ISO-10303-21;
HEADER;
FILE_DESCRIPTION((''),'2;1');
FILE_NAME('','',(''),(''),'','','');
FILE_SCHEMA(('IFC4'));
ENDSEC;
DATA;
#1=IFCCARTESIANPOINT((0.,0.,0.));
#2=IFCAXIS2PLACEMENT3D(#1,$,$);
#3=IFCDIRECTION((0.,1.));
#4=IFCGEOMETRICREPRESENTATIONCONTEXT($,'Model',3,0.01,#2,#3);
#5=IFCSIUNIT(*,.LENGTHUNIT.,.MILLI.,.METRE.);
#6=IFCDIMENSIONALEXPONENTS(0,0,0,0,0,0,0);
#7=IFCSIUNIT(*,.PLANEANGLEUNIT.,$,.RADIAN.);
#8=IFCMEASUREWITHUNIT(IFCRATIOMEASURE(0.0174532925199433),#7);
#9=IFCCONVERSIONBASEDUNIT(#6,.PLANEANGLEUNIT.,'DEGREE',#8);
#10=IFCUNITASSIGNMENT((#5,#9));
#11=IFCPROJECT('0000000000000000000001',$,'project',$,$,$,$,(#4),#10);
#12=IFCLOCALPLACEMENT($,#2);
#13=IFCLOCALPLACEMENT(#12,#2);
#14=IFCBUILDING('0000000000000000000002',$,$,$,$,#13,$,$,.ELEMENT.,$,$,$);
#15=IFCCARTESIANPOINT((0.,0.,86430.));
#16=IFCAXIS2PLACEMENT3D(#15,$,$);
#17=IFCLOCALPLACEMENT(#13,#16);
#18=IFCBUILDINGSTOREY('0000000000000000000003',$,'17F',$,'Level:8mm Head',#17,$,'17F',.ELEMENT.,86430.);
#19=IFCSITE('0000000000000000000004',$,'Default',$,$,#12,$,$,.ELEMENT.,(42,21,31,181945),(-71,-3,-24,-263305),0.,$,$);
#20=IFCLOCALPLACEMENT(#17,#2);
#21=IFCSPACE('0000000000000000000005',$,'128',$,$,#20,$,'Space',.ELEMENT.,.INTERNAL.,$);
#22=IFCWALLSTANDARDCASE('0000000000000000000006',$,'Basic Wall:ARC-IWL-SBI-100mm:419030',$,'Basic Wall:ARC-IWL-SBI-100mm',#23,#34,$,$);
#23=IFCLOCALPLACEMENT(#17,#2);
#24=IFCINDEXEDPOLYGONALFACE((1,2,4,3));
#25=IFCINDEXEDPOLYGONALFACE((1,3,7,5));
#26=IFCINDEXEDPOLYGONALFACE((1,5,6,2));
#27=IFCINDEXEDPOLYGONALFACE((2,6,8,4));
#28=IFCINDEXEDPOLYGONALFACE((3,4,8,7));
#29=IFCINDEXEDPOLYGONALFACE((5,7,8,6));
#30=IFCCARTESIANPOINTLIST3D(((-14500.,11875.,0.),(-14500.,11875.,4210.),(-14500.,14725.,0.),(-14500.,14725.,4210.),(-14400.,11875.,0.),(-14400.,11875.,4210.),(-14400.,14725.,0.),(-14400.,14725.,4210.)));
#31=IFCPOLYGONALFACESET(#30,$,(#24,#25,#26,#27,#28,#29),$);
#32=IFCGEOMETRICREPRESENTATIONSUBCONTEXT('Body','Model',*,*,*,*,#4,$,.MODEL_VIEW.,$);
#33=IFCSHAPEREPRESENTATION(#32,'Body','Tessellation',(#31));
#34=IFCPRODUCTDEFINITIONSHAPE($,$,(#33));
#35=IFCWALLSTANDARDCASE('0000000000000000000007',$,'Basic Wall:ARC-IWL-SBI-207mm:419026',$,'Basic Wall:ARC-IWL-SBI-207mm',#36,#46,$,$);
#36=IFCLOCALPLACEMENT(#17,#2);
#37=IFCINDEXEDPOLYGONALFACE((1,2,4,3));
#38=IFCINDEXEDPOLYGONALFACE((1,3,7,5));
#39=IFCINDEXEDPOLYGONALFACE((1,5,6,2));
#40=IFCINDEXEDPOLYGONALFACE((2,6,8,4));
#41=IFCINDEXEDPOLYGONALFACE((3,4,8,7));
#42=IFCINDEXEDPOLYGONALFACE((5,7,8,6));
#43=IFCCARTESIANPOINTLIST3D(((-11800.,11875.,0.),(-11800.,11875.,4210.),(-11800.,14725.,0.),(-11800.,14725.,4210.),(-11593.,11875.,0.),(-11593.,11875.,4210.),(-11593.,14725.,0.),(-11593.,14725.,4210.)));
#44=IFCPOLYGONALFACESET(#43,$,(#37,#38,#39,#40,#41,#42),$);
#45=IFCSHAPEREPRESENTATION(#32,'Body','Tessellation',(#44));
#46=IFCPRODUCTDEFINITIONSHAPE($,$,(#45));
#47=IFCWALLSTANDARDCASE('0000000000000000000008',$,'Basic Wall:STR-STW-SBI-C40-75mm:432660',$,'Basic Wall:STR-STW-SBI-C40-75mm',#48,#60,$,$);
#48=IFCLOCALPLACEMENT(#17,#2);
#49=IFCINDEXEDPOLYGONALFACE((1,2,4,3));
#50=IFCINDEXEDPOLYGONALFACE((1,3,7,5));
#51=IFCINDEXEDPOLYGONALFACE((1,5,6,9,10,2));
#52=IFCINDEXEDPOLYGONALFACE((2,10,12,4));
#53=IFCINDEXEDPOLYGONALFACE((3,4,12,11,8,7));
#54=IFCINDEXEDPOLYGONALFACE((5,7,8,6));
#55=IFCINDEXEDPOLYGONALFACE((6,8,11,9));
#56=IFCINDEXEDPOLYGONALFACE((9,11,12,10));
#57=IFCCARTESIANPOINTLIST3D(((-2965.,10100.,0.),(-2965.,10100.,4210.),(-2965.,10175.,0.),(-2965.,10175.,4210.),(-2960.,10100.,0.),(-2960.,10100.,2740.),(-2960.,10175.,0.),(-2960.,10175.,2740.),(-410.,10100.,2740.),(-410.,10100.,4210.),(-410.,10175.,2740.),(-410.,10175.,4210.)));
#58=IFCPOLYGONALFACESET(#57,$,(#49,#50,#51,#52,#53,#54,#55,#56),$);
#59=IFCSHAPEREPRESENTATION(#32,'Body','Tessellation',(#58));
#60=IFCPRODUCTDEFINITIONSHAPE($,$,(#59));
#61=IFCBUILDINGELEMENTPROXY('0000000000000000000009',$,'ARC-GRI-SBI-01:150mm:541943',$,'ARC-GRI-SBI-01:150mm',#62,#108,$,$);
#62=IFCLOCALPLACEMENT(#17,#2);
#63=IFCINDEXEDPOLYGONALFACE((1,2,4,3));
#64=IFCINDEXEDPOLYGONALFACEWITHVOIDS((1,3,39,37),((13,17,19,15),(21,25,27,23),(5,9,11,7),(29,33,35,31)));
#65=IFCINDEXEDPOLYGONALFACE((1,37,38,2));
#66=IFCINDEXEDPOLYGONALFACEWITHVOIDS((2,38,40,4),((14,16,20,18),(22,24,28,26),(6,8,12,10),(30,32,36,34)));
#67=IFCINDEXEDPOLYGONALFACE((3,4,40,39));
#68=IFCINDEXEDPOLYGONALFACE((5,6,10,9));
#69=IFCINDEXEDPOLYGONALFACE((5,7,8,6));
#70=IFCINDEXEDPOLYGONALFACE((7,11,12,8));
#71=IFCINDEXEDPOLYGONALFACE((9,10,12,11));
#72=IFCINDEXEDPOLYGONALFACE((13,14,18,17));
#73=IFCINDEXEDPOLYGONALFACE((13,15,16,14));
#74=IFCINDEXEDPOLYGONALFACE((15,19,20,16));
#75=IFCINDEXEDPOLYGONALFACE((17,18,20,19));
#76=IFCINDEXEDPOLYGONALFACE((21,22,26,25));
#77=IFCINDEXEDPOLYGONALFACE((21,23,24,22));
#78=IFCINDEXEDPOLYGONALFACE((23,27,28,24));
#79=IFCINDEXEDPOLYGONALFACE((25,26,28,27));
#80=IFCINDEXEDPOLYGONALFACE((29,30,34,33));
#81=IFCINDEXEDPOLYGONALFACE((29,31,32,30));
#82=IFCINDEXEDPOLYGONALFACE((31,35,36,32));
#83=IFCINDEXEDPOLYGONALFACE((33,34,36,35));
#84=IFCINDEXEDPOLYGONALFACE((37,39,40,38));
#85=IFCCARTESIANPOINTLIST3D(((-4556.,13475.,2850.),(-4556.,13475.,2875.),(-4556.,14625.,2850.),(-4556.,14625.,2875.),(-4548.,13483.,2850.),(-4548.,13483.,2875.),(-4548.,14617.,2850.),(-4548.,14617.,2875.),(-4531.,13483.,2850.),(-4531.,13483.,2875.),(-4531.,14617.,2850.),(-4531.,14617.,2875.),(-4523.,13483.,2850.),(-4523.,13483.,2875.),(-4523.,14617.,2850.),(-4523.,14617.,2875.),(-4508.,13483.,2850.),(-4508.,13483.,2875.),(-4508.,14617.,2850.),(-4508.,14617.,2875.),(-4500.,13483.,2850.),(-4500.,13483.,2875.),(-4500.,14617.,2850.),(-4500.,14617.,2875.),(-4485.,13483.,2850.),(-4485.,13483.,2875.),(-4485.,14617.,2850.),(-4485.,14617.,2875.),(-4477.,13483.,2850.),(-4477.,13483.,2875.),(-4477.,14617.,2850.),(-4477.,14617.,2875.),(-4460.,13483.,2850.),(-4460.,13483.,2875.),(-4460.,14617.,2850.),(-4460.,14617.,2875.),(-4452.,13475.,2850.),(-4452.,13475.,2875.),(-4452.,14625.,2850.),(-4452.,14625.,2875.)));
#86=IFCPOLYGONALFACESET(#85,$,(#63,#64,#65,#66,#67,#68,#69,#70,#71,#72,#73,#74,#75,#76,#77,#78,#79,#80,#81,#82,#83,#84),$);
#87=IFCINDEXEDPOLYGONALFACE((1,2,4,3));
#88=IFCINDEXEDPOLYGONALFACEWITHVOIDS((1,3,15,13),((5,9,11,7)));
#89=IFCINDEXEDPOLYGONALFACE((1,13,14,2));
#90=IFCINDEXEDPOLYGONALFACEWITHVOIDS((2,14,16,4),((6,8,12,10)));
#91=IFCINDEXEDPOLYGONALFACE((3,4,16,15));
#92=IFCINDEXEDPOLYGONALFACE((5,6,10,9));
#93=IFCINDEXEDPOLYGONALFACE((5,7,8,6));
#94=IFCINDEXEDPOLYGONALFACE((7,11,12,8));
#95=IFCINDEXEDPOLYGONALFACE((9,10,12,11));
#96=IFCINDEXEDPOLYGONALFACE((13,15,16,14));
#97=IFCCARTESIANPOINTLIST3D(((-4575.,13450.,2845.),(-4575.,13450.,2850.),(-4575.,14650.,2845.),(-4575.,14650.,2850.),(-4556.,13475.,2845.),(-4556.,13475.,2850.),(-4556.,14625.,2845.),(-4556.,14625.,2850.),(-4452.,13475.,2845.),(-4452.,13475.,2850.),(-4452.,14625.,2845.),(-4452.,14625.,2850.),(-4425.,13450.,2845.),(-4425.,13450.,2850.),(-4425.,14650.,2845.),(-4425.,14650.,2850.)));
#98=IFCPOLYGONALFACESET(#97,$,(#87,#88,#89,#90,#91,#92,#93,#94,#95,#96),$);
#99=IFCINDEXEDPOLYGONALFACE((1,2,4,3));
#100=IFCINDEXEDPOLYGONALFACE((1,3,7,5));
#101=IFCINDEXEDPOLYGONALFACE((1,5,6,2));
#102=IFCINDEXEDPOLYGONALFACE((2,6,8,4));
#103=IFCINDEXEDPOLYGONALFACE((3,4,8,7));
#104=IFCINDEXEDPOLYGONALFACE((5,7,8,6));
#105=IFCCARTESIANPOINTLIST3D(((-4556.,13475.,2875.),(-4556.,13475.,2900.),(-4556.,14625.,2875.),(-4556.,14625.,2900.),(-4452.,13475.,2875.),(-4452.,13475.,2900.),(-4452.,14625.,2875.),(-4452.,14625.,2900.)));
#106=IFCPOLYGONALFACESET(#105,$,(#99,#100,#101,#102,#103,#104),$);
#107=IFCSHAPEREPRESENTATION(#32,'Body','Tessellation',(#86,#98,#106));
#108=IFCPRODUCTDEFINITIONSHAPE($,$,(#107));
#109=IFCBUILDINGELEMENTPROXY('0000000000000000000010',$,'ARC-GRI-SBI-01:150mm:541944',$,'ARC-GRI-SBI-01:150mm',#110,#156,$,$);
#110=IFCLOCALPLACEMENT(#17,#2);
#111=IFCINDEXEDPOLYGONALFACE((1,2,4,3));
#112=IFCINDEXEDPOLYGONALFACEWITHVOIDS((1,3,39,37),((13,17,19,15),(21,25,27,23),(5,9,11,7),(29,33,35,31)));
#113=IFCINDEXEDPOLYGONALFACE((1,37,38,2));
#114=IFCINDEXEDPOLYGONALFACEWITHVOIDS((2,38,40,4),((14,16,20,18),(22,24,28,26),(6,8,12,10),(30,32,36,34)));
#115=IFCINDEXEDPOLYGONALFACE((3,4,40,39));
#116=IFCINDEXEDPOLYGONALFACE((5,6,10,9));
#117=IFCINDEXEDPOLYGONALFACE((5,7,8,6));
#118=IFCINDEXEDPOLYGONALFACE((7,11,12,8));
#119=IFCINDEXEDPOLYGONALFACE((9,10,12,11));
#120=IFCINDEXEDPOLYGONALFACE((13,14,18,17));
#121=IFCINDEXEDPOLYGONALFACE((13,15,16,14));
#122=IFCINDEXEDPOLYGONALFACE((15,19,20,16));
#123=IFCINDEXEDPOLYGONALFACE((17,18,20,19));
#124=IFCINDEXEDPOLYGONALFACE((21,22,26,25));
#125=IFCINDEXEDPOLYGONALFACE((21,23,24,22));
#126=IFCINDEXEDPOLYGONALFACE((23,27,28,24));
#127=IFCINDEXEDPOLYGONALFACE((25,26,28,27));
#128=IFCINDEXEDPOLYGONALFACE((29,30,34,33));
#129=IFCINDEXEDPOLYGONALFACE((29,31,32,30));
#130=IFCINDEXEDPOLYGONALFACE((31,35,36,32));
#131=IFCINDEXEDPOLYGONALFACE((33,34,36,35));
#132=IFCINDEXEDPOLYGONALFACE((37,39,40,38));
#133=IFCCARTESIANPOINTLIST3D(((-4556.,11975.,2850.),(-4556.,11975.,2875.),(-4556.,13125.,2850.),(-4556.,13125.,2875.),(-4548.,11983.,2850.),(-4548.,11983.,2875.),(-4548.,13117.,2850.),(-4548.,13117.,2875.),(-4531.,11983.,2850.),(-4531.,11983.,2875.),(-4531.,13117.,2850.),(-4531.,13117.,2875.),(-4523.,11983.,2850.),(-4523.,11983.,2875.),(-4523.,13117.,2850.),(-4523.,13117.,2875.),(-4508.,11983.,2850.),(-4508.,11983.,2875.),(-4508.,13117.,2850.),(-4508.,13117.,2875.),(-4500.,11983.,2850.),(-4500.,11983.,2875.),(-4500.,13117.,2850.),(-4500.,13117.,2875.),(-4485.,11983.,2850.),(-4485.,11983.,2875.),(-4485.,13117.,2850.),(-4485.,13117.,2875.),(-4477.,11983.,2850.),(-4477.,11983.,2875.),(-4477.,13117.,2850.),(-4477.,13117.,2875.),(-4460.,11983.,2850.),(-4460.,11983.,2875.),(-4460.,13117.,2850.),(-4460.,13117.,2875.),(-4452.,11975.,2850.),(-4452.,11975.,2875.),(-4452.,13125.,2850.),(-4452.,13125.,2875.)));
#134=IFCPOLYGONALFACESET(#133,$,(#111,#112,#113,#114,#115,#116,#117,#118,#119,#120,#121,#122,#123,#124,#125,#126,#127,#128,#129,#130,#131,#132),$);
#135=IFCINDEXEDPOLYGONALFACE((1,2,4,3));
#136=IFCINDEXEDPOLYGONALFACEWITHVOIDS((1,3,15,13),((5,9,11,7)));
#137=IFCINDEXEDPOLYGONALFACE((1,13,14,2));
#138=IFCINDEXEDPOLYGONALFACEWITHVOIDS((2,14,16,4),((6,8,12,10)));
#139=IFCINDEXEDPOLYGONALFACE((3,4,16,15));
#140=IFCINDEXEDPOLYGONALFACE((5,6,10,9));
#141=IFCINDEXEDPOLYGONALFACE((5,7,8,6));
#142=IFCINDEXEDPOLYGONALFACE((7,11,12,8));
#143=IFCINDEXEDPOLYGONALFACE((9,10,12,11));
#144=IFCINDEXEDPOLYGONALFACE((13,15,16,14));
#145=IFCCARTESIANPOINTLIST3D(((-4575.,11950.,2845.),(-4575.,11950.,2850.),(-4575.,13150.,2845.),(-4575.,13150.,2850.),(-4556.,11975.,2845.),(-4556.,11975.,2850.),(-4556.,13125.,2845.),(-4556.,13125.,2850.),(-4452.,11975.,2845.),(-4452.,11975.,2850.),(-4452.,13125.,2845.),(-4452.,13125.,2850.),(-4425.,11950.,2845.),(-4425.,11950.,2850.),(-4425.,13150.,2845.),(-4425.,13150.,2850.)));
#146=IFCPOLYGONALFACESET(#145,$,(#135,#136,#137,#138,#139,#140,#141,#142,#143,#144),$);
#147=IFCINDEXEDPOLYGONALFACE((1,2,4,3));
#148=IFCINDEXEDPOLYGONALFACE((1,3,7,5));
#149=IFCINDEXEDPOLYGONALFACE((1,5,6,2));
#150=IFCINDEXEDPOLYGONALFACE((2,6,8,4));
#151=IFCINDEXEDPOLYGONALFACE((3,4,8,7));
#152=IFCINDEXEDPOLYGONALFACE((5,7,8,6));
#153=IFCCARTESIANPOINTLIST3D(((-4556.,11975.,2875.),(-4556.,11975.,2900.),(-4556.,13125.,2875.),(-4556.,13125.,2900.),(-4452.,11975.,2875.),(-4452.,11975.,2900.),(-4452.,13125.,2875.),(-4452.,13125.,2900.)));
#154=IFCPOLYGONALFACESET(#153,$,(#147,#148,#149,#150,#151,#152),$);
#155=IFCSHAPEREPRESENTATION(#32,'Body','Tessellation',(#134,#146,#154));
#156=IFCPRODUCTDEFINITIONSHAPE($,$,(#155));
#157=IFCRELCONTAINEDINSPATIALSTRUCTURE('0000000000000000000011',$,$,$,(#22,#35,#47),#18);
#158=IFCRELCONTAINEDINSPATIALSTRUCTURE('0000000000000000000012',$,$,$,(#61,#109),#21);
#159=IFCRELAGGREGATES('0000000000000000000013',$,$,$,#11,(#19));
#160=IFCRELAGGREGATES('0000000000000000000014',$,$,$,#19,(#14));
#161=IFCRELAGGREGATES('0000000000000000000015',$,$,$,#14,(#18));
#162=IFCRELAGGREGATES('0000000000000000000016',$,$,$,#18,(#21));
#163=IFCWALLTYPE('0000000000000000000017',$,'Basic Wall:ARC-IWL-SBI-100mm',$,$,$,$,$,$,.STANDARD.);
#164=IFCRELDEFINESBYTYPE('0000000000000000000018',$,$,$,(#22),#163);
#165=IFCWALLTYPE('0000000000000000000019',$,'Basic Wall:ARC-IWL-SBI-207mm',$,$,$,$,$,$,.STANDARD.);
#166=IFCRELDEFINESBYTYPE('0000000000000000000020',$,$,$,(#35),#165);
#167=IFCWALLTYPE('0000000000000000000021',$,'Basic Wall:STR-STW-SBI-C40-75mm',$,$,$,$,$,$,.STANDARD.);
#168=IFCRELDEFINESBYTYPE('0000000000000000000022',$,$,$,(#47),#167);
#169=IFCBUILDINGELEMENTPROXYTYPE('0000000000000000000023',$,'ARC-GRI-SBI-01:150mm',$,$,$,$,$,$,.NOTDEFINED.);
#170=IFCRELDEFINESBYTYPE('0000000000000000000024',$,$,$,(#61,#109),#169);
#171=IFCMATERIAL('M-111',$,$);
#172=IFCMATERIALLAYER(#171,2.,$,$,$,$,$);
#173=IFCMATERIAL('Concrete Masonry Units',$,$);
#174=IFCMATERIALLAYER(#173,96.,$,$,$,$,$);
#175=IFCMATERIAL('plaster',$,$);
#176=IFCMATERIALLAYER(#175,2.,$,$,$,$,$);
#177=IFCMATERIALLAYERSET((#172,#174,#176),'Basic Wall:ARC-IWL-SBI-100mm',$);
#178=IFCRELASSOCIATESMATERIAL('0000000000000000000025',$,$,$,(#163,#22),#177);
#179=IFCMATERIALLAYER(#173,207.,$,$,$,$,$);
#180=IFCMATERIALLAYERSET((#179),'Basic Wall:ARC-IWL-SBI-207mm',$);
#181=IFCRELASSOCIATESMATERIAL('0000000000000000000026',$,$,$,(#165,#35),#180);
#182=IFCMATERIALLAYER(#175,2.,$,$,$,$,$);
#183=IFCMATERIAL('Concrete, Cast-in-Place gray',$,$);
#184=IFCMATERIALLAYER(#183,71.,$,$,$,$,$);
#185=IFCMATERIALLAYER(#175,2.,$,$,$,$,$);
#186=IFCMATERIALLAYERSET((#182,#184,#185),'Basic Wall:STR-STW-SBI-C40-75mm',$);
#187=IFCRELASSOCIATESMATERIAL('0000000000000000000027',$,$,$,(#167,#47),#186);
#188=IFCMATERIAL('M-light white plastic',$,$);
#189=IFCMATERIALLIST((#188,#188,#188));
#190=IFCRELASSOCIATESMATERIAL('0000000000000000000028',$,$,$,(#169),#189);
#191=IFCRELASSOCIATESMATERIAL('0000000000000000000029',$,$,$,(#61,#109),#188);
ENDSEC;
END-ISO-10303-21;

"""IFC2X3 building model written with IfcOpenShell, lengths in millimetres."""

from ifc_helpers import new_model, entity, si_unit, converted_unit, direction, frame, frame_2d, origin, origin_2d_with_axis, place, context, subcontext, project, spatial, polyline, rectangle, outline, extrude, source, transform, mapped, material, material_list, layer, layer_set, layer_usage, type_object, type_shapes, element, save


model = new_model("IFC2X3")

# Units and contexts
model_context = context("Model", 3, precision=0.01, world=origin(), true_north=direction((0.0, 1.0)))
body_context = subcontext(model_context, "Body", "Model", "MODEL_VIEW")
ifc_project = project(units=[si_unit("LENGTHUNIT", "METRE", prefix="MILLI"), converted_unit("PLANEANGLEUNIT", "DEGREE", entity("IfcRatioMeasure", 0.0174532925199433), si_unit("PLANEANGLEUNIT", "RADIAN"), dimensions=[0, 0, 0, 0, 0, 0, 0])], contexts=[model_context])

# Site, building, storey
site_placement = place(None, origin())
site = spatial("IfcSite", under=ifc_project, at=site_placement, Name="Default", CompositionType="ELEMENT", RefLatitude=(42, 21, 31, 181945), RefLongitude=(-71, -3, -24, -263305), RefElevation=0.0)
building_placement = place(site_placement, origin())
building = spatial("IfcBuilding", under=site, at=building_placement, CompositionType="ELEMENT")
storey_placement = place(building_placement, frame((0.0, 0.0, 86430.0)))
storey = spatial("IfcBuildingStorey", under=building, at=storey_placement, Name="17F", ObjectType="Level:8mm Head", LongName="17F", CompositionType="ELEMENT", Elevation=86430.0)

# Walls
ifc_material_1 = material(Name="Concrete, Cast-in-Place gray")
ifc_material_2 = material(Name="M-111")
ifc_layer_1 = layer(ifc_material_2, 2.0)
ifc_material_3 = material(Name="Concrete Masonry Units")
ifc_layer_2 = layer(ifc_material_3, 96.0)
ifc_material_4 = material(Name="plaster")
ifc_layer_3 = layer(ifc_material_4, 2.0)
ifc_layer_set_1 = layer_set([ifc_layer_1, ifc_layer_2, ifc_layer_3], Name="Basic Wall:ARC-IWL-SBI-100mm")
wall_type_1 = type_object("IfcWallType", Name="Basic Wall:ARC-IWL-SBI-100mm", PredefinedType="STANDARD", material=ifc_layer_set_1)
ifc_layer_usage_1 = layer_usage(ifc_layer_set_1, "AXIS2", "NEGATIVE", 50.0)
wall_1_placement = place(storey_placement, frame((-14450.0, 11875.0, 0.0), z_axis=(0.0, 0.0, 1.0), x_axis=(0.0, 1.0, 0.0)))
element("IfcWallStandardCase", 1, at=wall_1_placement, inside=storey, type_object=wall_type_1, material=ifc_layer_usage_1, Name="Basic Wall:ARC-IWL-SBI-100mm:419030", ObjectType="Basic Wall:ARC-IWL-SBI-100mm", context=body_context, shape_type="SweptSolid", body=[
    extrude(rectangle(XDim=2850.0, YDim=100.0, at=frame_2d((1425.0, 0.0), x_axis=(-1.0, 0.0))), origin(), (0.0, 0.0, 1.0), 4210.0),
])
ifc_layer_4 = layer(ifc_material_3, 207.0)
ifc_layer_set_2 = layer_set([ifc_layer_4], Name="Basic Wall:ARC-IWL-SBI-207mm")
ifc_layer_usage_2 = layer_usage(ifc_layer_set_2, "AXIS2", "NEGATIVE", 103.5)
wall_type_2 = type_object("IfcWallType", Name="Basic Wall:ARC-IWL-SBI-207mm", PredefinedType="STANDARD", material=ifc_layer_set_2)
wall_2_placement = place(storey_placement, frame((-11696.5, 14725.0, 0.0), z_axis=(0.0, 0.0, 1.0), x_axis=(0.0, -1.0, 0.0)))
element("IfcWallStandardCase", 2, at=wall_2_placement, inside=storey, type_object=wall_type_2, material=ifc_layer_usage_2, Name="Basic Wall:ARC-IWL-SBI-207mm:419026", ObjectType="Basic Wall:ARC-IWL-SBI-207mm", context=body_context, shape_type="SweptSolid", body=[
    extrude(rectangle(XDim=2850.0, YDim=207.0, at=frame_2d((1425.0, 0.0), x_axis=(-1.0, 0.0))), origin(), (0.0, 0.0, 1.0), 4210.0),
])

# Wall, opening
ifc_layer_5 = layer(ifc_material_4, 2.0)
ifc_layer_6 = layer(ifc_material_1, 71.0)
ifc_layer_7 = layer(ifc_material_4, 2.0)
ifc_layer_set_3 = layer_set([ifc_layer_5, ifc_layer_6, ifc_layer_7], Name="Basic Wall:STR-STW-SBI-C40-75mm")
ifc_layer_usage_3 = layer_usage(ifc_layer_set_3, "AXIS2", "NEGATIVE", 37.5)
wall_type_3 = type_object("IfcWallType", Name="Basic Wall:STR-STW-SBI-C40-75mm", PredefinedType="STANDARD", material=ifc_layer_set_3)
wall_3_placement = place(storey_placement, frame((-2965.0, 10137.5, 0.0)))
wall_3 = element("IfcWallStandardCase", 3, at=wall_3_placement, inside=storey, type_object=wall_type_3, material=ifc_layer_usage_3, Name="Basic Wall:STR-STW-SBI-C40-75mm:432660", ObjectType="Basic Wall:STR-STW-SBI-C40-75mm", context=body_context, shape_type="SweptSolid", body=[
    extrude(rectangle(XDim=2555.0, YDim=75.0, at=frame_2d((1277.5, 0.0), x_axis=(-1.0, 0.0))), origin(), (0.0, 0.0, 1.0), 4210.0),
])
opening_1_placement = place(wall_3_placement, frame((5.0, -37.5, 0.0)))
element("IfcOpeningElement", 4, at=opening_1_placement, cuts=wall_3, ObjectType="Opening", context=body_context, shape_type="SweptSolid", body=[
    extrude(rectangle(XDim=2740.0, YDim=2550.0, at=frame_2d((1370.0, 1275.0), x_axis=(1.0, 0.0))), frame((0.0, 0.0, 0.0), z_axis=(0.0, 1.0, 0.0), x_axis=(0.0, 0.0, 1.0)), (0.0, 0.0, 1.0), 75.0),
])

# Shared definitions
space_placement = place(storey_placement, origin())
space = spatial("IfcSpace", under=storey, at=space_placement, Name="128", LongName="Space", CompositionType="ELEMENT", InteriorOrExteriorSpace="INTERNAL")

# Building element proxies
ifc_material_5 = material(Name="M-light white plastic")
ifc_material_list = material_list([ifc_material_5, ifc_material_5, ifc_material_5])
building_element_proxy_type = type_object("IfcBuildingElementProxyType", Name="ARC-GRI-SBI-01:150mm", PredefinedType="NOTDEFINED", material=ifc_material_list)
shared_shape = source(origin(), body_context, "Body", "SweptSolid", [
    extrude(outline(polyline([(-575.0, -52.0), (575.0, -52.0), (575.0, 52.0), (-575.0, 52.0), (-575.0, -52.0)]), holes=[polyline([(-567.0, -44.0), (-567.0, -27.0), (567.0, -27.0), (567.0, -44.0), (-567.0, -44.0)]), polyline([(567.0, -4.0), (567.0, -19.0), (-567.0, -19.0), (-567.0, -4.0), (567.0, -4.0)]), polyline([(-567.0, 44.0), (567.0, 44.0), (567.0, 27.0), (-567.0, 27.0), (-567.0, 44.0)]), polyline([(567.0, 4.0), (-567.0, 4.0), (-567.0, 19.0), (567.0, 19.0), (567.0, 4.0)])]), frame((425.0, 4.0, 4000.0), z_axis=(0.0, 0.0, 1.0), x_axis=(-1.0, 0.0, 0.0)), (0.0, 0.0, 1.0), 25.0),
    extrude(outline(polyline([(-600.0, -75.0), (600.0, -75.0), (600.0, 75.0), (-600.0, 75.0), (-600.0, -75.0)]), holes=[polyline([(-575.0, -56.0), (-575.0, 48.0), (575.0, 48.0), (575.0, -56.0), (-575.0, -56.0)])]), frame((425.0, 0.0, 3995.0), z_axis=(0.0, 0.0, 1.0), x_axis=(-1.0, 0.0, 0.0)), (0.0, 0.0, 1.0), 5.0),
    extrude(rectangle(XDim=1150.0, YDim=104.0, at=origin_2d_with_axis()), frame((425.0, 4.0, 4025.0), z_axis=(0.0, 0.0, 1.0), x_axis=(-1.0, 0.0, 0.0)), (0.0, 0.0, 1.0), 25.0),
])
type_shapes(building_element_proxy_type, [shared_shape])
for number, where, z_axis, x_axis, name in (
    (5, (-4500.0, 13625.0, -1150.0), (0.0, 0.0, 1.0), (0.0, 1.0, 0.0), "ARC-GRI-SBI-01:150mm:541943"),
    (6, (-4500.0, 12125.0, -1150.0), (0.0, 0.0, 1.0), (0.0, 1.0, 0.0), "ARC-GRI-SBI-01:150mm:541944"),
):
    element("IfcBuildingElementProxy", number, at=place(space_placement, frame(where, z_axis=z_axis, x_axis=x_axis)), inside=space, type_object=building_element_proxy_type, material=ifc_material_5, Name=name, ObjectType="ARC-GRI-SBI-01:150mm", context=body_context, shape_type="MappedRepresentation", body=[
        mapped(shared_shape, transform((0.0, 0.0, 0.0), scale=1.0)),
    ])

save(model, "model.ifc")
